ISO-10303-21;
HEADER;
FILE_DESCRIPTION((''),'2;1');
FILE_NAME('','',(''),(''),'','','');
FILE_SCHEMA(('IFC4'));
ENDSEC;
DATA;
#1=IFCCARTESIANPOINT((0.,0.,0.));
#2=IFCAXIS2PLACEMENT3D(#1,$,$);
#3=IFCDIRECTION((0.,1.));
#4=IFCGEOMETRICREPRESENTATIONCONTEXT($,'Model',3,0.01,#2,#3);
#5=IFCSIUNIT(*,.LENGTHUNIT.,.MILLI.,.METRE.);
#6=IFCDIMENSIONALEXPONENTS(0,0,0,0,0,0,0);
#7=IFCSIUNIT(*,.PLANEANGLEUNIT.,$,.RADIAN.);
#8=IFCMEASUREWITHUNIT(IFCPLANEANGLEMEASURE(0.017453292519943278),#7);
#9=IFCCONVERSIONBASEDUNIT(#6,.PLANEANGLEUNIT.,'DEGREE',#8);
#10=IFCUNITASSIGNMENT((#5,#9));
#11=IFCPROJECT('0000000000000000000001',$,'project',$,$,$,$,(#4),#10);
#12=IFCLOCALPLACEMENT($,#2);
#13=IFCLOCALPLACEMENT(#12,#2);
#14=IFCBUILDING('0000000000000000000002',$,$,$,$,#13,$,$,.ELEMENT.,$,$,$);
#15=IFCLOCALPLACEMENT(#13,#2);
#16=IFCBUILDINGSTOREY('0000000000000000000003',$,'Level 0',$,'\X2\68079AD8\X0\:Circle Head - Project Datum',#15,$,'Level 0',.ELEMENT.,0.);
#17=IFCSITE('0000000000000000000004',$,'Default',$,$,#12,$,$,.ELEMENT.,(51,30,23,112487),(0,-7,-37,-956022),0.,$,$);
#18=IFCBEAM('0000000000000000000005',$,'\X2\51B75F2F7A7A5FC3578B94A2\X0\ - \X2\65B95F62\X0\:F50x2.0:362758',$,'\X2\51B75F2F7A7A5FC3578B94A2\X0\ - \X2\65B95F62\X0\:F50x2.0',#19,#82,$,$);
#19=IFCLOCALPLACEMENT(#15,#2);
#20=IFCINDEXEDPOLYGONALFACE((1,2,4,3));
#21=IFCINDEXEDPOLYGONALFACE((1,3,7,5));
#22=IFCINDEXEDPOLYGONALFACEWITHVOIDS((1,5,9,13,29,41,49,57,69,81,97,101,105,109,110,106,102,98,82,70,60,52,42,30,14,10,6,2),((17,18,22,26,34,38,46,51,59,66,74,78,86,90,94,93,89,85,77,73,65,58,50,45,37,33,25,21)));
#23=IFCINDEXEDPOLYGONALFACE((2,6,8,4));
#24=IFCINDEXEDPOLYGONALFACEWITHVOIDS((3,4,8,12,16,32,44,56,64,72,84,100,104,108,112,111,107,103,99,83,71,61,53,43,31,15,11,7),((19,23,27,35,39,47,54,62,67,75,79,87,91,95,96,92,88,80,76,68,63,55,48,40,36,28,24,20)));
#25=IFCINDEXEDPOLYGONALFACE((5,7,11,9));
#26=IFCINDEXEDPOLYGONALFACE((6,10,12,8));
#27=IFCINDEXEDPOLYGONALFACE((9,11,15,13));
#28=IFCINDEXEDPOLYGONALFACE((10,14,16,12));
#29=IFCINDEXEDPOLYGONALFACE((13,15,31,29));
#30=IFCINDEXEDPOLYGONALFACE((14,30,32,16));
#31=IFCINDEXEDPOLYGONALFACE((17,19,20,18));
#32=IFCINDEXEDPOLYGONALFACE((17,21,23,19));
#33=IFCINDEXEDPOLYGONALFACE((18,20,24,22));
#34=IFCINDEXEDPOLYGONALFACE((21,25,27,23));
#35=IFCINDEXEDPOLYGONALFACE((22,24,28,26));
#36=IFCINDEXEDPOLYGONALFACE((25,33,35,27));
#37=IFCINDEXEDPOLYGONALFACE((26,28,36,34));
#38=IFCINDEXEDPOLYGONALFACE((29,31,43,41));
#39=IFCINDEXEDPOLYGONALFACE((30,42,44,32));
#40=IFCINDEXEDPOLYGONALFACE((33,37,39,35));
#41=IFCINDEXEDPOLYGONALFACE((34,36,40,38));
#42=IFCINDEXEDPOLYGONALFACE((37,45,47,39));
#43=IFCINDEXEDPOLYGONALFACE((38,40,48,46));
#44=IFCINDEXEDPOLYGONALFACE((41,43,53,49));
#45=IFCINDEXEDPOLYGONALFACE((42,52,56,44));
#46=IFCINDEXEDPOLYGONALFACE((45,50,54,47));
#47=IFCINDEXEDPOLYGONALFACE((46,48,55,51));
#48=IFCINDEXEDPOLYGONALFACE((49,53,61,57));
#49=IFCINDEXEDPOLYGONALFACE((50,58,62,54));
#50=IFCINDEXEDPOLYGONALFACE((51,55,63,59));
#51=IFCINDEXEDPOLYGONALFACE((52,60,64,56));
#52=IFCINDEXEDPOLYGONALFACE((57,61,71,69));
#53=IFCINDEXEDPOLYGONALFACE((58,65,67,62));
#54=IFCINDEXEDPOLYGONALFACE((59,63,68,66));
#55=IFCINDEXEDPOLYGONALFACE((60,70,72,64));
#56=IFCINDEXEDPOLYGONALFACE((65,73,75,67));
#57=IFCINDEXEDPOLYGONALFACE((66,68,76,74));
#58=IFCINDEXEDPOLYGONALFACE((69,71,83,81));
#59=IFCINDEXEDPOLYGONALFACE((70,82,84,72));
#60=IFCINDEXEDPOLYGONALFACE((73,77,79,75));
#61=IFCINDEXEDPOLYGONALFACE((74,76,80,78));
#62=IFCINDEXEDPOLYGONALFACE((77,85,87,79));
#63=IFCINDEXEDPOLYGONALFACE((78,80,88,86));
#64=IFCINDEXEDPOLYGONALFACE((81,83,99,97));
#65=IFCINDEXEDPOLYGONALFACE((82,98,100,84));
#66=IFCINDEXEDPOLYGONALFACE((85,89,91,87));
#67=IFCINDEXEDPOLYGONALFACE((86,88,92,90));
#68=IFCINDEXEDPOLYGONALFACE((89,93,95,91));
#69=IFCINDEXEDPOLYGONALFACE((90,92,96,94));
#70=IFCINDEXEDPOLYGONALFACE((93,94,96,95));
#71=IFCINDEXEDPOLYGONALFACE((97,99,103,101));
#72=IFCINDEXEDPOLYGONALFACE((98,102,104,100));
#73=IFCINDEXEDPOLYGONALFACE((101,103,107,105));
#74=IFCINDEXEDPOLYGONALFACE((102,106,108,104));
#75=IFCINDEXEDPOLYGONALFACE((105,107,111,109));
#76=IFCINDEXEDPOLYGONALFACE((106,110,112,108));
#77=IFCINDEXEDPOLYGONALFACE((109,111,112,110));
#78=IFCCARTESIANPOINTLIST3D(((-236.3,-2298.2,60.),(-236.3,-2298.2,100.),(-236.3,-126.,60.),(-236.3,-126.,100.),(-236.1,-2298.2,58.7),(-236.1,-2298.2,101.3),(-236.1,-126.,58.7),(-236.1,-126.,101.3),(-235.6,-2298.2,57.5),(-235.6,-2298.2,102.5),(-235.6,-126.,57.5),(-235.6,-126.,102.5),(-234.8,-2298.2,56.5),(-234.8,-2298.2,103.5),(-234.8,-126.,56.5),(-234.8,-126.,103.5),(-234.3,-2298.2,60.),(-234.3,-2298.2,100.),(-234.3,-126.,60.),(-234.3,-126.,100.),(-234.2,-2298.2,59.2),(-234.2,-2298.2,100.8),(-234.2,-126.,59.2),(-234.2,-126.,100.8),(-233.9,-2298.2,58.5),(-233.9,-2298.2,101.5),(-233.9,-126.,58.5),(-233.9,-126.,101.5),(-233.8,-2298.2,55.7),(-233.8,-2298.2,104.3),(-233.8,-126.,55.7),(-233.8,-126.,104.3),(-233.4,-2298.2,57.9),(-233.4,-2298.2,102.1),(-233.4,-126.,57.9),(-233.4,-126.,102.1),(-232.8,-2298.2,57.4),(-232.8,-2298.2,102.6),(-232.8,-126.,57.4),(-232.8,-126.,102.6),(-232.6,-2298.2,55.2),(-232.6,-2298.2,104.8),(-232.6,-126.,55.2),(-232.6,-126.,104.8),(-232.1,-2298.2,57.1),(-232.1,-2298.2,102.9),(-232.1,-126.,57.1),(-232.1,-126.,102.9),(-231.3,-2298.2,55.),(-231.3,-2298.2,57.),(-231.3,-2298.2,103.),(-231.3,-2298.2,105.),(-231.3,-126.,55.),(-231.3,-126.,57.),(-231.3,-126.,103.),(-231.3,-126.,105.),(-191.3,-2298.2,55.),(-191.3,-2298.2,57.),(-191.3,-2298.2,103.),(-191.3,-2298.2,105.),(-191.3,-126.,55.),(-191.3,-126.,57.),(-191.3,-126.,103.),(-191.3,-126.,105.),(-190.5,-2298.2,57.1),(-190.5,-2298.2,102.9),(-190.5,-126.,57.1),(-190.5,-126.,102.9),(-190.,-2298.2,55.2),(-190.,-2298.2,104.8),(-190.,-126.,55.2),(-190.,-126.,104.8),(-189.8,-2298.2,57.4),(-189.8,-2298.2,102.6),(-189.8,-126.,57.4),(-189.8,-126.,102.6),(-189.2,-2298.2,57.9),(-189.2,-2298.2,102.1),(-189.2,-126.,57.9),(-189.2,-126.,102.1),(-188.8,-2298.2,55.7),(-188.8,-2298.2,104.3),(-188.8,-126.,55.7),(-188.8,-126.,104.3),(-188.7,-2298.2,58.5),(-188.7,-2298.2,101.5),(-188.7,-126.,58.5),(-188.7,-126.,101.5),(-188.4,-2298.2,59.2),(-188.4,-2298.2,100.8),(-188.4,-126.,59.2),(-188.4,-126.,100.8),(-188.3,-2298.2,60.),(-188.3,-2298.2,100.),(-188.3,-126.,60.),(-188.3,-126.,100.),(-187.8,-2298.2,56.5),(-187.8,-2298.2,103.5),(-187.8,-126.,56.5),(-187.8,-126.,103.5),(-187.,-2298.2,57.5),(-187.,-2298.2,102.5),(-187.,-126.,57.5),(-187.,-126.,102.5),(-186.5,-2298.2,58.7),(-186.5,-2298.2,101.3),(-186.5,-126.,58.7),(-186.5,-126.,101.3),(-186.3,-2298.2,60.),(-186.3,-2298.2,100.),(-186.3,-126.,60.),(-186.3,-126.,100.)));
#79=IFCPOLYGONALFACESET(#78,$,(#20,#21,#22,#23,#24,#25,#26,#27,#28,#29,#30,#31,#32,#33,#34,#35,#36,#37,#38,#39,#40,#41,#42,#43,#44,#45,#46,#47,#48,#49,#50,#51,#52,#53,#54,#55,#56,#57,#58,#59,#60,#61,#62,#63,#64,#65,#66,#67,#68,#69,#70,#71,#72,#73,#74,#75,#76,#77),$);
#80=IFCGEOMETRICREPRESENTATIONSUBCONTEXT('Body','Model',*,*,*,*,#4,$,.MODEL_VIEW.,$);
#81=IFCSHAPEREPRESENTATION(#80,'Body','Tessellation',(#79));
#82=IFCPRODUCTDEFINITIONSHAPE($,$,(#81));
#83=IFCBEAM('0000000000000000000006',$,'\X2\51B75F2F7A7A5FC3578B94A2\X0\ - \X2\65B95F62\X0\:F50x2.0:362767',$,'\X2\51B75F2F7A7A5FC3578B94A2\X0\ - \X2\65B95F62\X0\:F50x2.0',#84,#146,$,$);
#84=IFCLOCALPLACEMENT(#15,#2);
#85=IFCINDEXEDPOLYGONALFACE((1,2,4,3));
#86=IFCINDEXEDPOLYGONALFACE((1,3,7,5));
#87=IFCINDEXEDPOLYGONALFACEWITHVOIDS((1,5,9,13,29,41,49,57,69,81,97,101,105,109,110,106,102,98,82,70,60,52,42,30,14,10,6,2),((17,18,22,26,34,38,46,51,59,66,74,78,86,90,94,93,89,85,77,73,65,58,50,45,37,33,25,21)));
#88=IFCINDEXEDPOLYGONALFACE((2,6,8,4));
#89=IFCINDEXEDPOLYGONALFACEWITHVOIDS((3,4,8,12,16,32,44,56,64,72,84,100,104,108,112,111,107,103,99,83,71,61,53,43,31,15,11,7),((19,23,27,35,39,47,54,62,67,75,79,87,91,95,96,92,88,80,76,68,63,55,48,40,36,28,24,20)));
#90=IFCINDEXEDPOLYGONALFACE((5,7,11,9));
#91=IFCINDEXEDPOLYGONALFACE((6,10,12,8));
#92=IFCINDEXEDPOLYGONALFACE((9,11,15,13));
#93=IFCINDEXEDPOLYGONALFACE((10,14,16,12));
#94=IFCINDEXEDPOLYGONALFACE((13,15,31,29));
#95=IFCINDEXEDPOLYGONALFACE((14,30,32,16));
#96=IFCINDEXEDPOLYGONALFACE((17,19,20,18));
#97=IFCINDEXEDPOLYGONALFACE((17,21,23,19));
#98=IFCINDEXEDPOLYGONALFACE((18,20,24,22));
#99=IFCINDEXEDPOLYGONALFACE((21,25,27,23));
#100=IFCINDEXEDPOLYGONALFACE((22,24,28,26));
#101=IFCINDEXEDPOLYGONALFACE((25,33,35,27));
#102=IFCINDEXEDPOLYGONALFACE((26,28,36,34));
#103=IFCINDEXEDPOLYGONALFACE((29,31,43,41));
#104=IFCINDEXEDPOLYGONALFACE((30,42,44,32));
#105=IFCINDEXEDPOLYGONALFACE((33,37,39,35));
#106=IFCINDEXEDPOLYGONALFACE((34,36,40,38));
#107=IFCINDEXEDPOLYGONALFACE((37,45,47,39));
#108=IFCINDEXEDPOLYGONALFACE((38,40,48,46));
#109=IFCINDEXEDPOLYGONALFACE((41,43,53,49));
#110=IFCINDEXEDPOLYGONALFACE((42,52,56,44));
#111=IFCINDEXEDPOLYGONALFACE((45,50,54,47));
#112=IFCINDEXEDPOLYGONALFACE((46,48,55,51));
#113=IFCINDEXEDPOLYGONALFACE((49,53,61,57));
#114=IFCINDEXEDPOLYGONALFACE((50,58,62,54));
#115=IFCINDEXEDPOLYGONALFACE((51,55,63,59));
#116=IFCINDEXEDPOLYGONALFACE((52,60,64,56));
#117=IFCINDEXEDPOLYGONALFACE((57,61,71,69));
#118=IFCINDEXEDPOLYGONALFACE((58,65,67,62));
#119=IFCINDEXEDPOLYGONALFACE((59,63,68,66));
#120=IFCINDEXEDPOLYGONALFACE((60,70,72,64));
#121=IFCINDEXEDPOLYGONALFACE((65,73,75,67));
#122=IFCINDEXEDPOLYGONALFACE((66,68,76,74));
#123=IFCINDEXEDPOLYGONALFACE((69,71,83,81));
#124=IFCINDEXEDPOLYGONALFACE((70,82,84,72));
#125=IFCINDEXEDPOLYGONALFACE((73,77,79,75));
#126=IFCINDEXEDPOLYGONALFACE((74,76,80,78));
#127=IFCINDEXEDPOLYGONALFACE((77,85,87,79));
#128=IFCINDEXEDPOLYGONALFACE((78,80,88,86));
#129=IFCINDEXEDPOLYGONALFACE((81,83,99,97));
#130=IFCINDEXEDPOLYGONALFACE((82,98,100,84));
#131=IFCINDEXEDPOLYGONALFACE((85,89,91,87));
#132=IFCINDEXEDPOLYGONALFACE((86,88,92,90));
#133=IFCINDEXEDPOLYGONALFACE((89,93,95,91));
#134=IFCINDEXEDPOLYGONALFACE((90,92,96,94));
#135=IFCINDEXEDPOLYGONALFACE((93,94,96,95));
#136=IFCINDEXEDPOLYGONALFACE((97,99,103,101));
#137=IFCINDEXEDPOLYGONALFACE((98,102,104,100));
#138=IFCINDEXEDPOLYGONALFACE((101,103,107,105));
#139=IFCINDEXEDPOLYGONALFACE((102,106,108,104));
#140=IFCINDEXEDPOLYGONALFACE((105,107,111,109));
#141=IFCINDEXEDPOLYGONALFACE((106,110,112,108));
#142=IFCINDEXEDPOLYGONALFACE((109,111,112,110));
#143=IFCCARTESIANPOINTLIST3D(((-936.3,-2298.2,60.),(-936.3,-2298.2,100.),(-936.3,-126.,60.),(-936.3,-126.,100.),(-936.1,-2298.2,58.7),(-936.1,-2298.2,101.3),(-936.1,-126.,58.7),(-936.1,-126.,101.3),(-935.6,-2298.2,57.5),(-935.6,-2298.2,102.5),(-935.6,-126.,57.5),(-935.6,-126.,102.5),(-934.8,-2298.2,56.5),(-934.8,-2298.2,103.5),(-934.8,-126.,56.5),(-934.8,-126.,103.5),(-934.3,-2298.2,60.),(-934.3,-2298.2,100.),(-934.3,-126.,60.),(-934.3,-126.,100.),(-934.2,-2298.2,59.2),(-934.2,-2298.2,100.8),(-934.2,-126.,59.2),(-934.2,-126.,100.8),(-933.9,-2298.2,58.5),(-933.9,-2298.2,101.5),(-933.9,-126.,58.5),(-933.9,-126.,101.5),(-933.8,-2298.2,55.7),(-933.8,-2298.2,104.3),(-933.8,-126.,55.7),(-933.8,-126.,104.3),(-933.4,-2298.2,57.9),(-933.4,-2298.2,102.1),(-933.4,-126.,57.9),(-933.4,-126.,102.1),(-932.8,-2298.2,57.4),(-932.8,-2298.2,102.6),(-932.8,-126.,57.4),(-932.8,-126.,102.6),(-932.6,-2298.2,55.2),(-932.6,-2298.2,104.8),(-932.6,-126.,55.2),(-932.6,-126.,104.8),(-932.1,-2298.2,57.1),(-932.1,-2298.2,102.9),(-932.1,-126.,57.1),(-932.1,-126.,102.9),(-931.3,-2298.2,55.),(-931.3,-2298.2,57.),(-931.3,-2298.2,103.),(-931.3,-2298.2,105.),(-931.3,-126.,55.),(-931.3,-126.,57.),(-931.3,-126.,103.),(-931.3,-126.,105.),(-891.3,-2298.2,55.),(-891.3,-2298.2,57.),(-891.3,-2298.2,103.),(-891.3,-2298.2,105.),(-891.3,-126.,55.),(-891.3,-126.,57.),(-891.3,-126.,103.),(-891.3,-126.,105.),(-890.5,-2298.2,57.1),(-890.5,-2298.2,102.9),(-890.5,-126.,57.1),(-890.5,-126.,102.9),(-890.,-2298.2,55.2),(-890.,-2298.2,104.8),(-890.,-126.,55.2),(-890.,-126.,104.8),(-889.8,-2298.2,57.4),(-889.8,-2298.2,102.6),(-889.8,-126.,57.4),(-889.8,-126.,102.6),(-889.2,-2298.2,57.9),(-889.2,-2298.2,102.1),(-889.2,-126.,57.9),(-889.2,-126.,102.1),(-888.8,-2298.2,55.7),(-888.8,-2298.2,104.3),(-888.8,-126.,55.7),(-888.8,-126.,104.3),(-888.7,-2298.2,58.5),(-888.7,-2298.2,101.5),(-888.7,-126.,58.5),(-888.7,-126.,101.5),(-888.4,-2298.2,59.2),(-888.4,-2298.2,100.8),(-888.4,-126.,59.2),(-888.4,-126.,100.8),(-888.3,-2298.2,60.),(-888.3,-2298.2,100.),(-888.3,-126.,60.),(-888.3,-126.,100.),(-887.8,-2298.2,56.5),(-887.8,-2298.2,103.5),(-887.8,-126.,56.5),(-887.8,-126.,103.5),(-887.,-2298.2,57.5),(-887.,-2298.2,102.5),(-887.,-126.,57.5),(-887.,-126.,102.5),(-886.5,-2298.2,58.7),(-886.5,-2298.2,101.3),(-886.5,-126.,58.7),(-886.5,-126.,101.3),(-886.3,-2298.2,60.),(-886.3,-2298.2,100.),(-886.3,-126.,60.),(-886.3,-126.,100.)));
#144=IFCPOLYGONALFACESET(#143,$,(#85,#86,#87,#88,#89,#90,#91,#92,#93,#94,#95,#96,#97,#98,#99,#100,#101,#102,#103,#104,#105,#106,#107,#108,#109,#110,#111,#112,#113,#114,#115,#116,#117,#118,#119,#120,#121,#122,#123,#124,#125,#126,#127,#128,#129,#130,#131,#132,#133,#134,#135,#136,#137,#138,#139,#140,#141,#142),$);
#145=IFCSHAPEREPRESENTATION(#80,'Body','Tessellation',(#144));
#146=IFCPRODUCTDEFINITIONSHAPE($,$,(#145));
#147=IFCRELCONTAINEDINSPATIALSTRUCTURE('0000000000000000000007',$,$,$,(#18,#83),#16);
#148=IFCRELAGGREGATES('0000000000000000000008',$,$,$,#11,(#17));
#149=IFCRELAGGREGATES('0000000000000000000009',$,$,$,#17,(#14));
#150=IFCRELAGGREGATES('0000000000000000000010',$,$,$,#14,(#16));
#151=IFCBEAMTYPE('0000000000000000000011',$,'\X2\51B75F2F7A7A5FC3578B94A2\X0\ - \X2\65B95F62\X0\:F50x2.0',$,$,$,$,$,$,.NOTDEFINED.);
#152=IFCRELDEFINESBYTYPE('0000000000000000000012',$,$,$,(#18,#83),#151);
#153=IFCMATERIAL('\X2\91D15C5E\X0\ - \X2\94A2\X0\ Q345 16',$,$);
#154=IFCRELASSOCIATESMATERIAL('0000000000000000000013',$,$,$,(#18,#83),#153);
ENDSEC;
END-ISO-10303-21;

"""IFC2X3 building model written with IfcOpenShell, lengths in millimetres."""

from ifc_helpers import new_model, entity, si_unit, converted_unit, direction, frame, frame_2d, origin, place, context, subcontext, project, spatial, polyline, circle_curve, parameter, trimmed, segment, composite_curve, outline, extrude, material, type_object, element, save


model = new_model("IFC2X3")

# Units and contexts
model_context = context("Model", 3, precision=0.01, world=origin(), true_north=direction((0.0, 1.0)))
body_context = subcontext(model_context, "Body", "Model", "MODEL_VIEW")
ifc_project = project(units=[si_unit("LENGTHUNIT", "METRE", prefix="MILLI"), converted_unit("PLANEANGLEUNIT", "DEGREE", entity("IfcPlaneAngleMeasure", 0.017453292519943278), si_unit("PLANEANGLEUNIT", "RADIAN"), dimensions=[0, 0, 0, 0, 0, 0, 0])], contexts=[model_context])

# Site, building, storey
site_placement = place(None, origin())
site = spatial("IfcSite", under=ifc_project, at=site_placement, Name="Default", CompositionType="ELEMENT", RefLatitude=(51, 30, 23, 112487), RefLongitude=(0, -7, -37, -956022), RefElevation=0.0)
building_placement = place(site_placement, origin())
building = spatial("IfcBuilding", under=site, at=building_placement, CompositionType="ELEMENT")
storey_placement = place(building_placement, origin())
storey = spatial("IfcBuildingStorey", under=building, at=storey_placement, Name="Level 0", ObjectType="标高:Circle Head - Project Datum", LongName="Level 0", CompositionType="ELEMENT", Elevation=0.0)

# Beams
ifc_material_1 = material(Name="金属 - 钢 Q345 16")
beam_type_1 = type_object("IfcBeamType", Name="冷弯空心型钢 - 方形:F50x2.0", PredefinedType="NOTDEFINED")
beam_1_placement = place(storey_placement, frame((-211.3, -390.5, 105.0), z_axis=(0.0, 0.0, 1.0), x_axis=(0.0, -1.0, 0.0)))
element("IfcBeam", 1, at=beam_1_placement, inside=storey, type_object=beam_type_1, material=ifc_material_1, Name="冷弯空心型钢 - 方形:F50x2.0:362758", ObjectType="冷弯空心型钢 - 方形:F50x2.0", context=body_context, shape_type="SweptSolid", body=[
    extrude(outline(composite_curve([segment(trimmed(circle_curve(frame_2d((-20.0, 20.0), x_axis=(1.0, 0.0)), 5.0), [parameter(90.0)], [parameter(180.0)], True, "PARAMETER"), True, "CONTINUOUS"), segment(polyline([(-25.0, 20.0), (-25.0, -20.0)]), True, "CONTINUOUS"), segment(trimmed(circle_curve(frame_2d((-20.0, -20.0), x_axis=(1.0, 0.0)), 5.0), [parameter(180.0)], [parameter(270.0)], True, "PARAMETER"), True, "CONTINUOUS"), segment(polyline([(-20.0, -25.0), (20.0, -25.0)]), True, "CONTINUOUS"), segment(trimmed(circle_curve(frame_2d((20.0, -20.0), x_axis=(1.0, 0.0)), 5.0), [parameter(270.0)], [parameter(0.0)], True, "PARAMETER"), True, "CONTINUOUS"), segment(polyline([(25.0, -20.0), (25.0, 20.0)]), True, "CONTINUOUS"), segment(trimmed(circle_curve(frame_2d((20.0, 20.0), x_axis=(1.0, 0.0)), 5.0), [parameter(0.0)], [parameter(90.0)], True, "PARAMETER"), True, "CONTINUOUS"), segment(polyline([(20.0, 25.0), (-20.0, 25.0)]), True, "CONTINUOUS")], self_intersect=False), holes=[composite_curve([segment(polyline([(-20.0, 23.0), (20.0, 23.0)]), True, "CONTINUOUS"), segment(trimmed(circle_curve(frame_2d((20.0, 20.0), x_axis=(1.0, 0.0)), 3.0), [parameter(360.0)], [parameter(90.0)], True, "PARAMETER"), False, "CONTINUOUS"), segment(polyline([(23.0, 20.0), (23.0, -20.0)]), True, "CONTINUOUS"), segment(trimmed(circle_curve(frame_2d((20.0, -20.0), x_axis=(1.0, 0.0)), 3.0), [parameter(270.0)], [parameter(360.0)], True, "PARAMETER"), False, "CONTINUOUS"), segment(polyline([(20.0, -23.0), (-20.0, -23.0)]), True, "CONTINUOUS"), segment(trimmed(circle_curve(frame_2d((-20.0, -20.0), x_axis=(1.0, 0.0)), 3.0), [parameter(180.0)], [parameter(270.0)], True, "PARAMETER"), False, "CONTINUOUS"), segment(polyline([(-23.0, -20.0), (-23.0, 20.0)]), True, "CONTINUOUS"), segment(trimmed(circle_curve(frame_2d((-20.0, 20.0), x_axis=(1.0, 0.0)), 3.0), [parameter(90.0)], [parameter(180.0)], True, "PARAMETER"), False, "CONTINUOUS")], self_intersect=False)]), frame((-264.5, 0.0, -25.0), z_axis=(1.0, 0.0, 0.0), x_axis=(0.0, 1.0, 0.0)), (0.0, 0.0, 1.0), 2172.2),
])
beam_2_placement = place(storey_placement, frame((-911.3, -390.5, 105.0), z_axis=(0.0, 0.0, 1.0), x_axis=(0.0, -1.0, 0.0)))
element("IfcBeam", 2, at=beam_2_placement, inside=storey, type_object=beam_type_1, material=ifc_material_1, Name="冷弯空心型钢 - 方形:F50x2.0:362767", ObjectType="冷弯空心型钢 - 方形:F50x2.0", context=body_context, shape_type="SweptSolid", body=[
    extrude(outline(composite_curve([segment(trimmed(circle_curve(frame_2d((-20.0, 20.0), x_axis=(1.0, 0.0)), 5.0), [parameter(90.0)], [parameter(180.0)], True, "PARAMETER"), True, "CONTINUOUS"), segment(polyline([(-25.0, 20.0), (-25.0, -20.0)]), True, "CONTINUOUS"), segment(trimmed(circle_curve(frame_2d((-20.0, -20.0), x_axis=(1.0, 0.0)), 5.0), [parameter(180.0)], [parameter(270.0)], True, "PARAMETER"), True, "CONTINUOUS"), segment(polyline([(-20.0, -25.0), (20.0, -25.0)]), True, "CONTINUOUS"), segment(trimmed(circle_curve(frame_2d((20.0, -20.0), x_axis=(1.0, 0.0)), 5.0), [parameter(270.0)], [parameter(0.0)], True, "PARAMETER"), True, "CONTINUOUS"), segment(polyline([(25.0, -20.0), (25.0, 20.0)]), True, "CONTINUOUS"), segment(trimmed(circle_curve(frame_2d((20.0, 20.0), x_axis=(1.0, 0.0)), 5.0), [parameter(0.0)], [parameter(90.0)], True, "PARAMETER"), True, "CONTINUOUS"), segment(polyline([(20.0, 25.0), (-20.0, 25.0)]), True, "CONTINUOUS")], self_intersect=False), holes=[composite_curve([segment(polyline([(-20.0, 23.0), (20.0, 23.0)]), True, "CONTINUOUS"), segment(trimmed(circle_curve(frame_2d((20.0, 20.0), x_axis=(1.0, 0.0)), 3.0), [parameter(360.0)], [parameter(90.0)], True, "PARAMETER"), False, "CONTINUOUS"), segment(polyline([(23.0, 20.0), (23.0, -20.0)]), True, "CONTINUOUS"), segment(trimmed(circle_curve(frame_2d((20.0, -20.0), x_axis=(1.0, 0.0)), 3.0), [parameter(270.0)], [parameter(360.0)], True, "PARAMETER"), False, "CONTINUOUS"), segment(polyline([(20.0, -23.0), (-20.0, -23.0)]), True, "CONTINUOUS"), segment(trimmed(circle_curve(frame_2d((-20.0, -20.0), x_axis=(1.0, 0.0)), 3.0), [parameter(180.0)], [parameter(270.0)], True, "PARAMETER"), False, "CONTINUOUS"), segment(polyline([(-23.0, -20.0), (-23.0, 20.0)]), True, "CONTINUOUS"), segment(trimmed(circle_curve(frame_2d((-20.0, 20.0), x_axis=(1.0, 0.0)), 3.0), [parameter(90.0)], [parameter(180.0)], True, "PARAMETER"), False, "CONTINUOUS")], self_intersect=False)]), frame((-264.5, 0.0, -25.0), z_axis=(1.0, 0.0, 0.0), x_axis=(0.0, 1.0, 0.0)), (0.0, 0.0, 1.0), 2172.2),
])

save(model, "model.ifc")
